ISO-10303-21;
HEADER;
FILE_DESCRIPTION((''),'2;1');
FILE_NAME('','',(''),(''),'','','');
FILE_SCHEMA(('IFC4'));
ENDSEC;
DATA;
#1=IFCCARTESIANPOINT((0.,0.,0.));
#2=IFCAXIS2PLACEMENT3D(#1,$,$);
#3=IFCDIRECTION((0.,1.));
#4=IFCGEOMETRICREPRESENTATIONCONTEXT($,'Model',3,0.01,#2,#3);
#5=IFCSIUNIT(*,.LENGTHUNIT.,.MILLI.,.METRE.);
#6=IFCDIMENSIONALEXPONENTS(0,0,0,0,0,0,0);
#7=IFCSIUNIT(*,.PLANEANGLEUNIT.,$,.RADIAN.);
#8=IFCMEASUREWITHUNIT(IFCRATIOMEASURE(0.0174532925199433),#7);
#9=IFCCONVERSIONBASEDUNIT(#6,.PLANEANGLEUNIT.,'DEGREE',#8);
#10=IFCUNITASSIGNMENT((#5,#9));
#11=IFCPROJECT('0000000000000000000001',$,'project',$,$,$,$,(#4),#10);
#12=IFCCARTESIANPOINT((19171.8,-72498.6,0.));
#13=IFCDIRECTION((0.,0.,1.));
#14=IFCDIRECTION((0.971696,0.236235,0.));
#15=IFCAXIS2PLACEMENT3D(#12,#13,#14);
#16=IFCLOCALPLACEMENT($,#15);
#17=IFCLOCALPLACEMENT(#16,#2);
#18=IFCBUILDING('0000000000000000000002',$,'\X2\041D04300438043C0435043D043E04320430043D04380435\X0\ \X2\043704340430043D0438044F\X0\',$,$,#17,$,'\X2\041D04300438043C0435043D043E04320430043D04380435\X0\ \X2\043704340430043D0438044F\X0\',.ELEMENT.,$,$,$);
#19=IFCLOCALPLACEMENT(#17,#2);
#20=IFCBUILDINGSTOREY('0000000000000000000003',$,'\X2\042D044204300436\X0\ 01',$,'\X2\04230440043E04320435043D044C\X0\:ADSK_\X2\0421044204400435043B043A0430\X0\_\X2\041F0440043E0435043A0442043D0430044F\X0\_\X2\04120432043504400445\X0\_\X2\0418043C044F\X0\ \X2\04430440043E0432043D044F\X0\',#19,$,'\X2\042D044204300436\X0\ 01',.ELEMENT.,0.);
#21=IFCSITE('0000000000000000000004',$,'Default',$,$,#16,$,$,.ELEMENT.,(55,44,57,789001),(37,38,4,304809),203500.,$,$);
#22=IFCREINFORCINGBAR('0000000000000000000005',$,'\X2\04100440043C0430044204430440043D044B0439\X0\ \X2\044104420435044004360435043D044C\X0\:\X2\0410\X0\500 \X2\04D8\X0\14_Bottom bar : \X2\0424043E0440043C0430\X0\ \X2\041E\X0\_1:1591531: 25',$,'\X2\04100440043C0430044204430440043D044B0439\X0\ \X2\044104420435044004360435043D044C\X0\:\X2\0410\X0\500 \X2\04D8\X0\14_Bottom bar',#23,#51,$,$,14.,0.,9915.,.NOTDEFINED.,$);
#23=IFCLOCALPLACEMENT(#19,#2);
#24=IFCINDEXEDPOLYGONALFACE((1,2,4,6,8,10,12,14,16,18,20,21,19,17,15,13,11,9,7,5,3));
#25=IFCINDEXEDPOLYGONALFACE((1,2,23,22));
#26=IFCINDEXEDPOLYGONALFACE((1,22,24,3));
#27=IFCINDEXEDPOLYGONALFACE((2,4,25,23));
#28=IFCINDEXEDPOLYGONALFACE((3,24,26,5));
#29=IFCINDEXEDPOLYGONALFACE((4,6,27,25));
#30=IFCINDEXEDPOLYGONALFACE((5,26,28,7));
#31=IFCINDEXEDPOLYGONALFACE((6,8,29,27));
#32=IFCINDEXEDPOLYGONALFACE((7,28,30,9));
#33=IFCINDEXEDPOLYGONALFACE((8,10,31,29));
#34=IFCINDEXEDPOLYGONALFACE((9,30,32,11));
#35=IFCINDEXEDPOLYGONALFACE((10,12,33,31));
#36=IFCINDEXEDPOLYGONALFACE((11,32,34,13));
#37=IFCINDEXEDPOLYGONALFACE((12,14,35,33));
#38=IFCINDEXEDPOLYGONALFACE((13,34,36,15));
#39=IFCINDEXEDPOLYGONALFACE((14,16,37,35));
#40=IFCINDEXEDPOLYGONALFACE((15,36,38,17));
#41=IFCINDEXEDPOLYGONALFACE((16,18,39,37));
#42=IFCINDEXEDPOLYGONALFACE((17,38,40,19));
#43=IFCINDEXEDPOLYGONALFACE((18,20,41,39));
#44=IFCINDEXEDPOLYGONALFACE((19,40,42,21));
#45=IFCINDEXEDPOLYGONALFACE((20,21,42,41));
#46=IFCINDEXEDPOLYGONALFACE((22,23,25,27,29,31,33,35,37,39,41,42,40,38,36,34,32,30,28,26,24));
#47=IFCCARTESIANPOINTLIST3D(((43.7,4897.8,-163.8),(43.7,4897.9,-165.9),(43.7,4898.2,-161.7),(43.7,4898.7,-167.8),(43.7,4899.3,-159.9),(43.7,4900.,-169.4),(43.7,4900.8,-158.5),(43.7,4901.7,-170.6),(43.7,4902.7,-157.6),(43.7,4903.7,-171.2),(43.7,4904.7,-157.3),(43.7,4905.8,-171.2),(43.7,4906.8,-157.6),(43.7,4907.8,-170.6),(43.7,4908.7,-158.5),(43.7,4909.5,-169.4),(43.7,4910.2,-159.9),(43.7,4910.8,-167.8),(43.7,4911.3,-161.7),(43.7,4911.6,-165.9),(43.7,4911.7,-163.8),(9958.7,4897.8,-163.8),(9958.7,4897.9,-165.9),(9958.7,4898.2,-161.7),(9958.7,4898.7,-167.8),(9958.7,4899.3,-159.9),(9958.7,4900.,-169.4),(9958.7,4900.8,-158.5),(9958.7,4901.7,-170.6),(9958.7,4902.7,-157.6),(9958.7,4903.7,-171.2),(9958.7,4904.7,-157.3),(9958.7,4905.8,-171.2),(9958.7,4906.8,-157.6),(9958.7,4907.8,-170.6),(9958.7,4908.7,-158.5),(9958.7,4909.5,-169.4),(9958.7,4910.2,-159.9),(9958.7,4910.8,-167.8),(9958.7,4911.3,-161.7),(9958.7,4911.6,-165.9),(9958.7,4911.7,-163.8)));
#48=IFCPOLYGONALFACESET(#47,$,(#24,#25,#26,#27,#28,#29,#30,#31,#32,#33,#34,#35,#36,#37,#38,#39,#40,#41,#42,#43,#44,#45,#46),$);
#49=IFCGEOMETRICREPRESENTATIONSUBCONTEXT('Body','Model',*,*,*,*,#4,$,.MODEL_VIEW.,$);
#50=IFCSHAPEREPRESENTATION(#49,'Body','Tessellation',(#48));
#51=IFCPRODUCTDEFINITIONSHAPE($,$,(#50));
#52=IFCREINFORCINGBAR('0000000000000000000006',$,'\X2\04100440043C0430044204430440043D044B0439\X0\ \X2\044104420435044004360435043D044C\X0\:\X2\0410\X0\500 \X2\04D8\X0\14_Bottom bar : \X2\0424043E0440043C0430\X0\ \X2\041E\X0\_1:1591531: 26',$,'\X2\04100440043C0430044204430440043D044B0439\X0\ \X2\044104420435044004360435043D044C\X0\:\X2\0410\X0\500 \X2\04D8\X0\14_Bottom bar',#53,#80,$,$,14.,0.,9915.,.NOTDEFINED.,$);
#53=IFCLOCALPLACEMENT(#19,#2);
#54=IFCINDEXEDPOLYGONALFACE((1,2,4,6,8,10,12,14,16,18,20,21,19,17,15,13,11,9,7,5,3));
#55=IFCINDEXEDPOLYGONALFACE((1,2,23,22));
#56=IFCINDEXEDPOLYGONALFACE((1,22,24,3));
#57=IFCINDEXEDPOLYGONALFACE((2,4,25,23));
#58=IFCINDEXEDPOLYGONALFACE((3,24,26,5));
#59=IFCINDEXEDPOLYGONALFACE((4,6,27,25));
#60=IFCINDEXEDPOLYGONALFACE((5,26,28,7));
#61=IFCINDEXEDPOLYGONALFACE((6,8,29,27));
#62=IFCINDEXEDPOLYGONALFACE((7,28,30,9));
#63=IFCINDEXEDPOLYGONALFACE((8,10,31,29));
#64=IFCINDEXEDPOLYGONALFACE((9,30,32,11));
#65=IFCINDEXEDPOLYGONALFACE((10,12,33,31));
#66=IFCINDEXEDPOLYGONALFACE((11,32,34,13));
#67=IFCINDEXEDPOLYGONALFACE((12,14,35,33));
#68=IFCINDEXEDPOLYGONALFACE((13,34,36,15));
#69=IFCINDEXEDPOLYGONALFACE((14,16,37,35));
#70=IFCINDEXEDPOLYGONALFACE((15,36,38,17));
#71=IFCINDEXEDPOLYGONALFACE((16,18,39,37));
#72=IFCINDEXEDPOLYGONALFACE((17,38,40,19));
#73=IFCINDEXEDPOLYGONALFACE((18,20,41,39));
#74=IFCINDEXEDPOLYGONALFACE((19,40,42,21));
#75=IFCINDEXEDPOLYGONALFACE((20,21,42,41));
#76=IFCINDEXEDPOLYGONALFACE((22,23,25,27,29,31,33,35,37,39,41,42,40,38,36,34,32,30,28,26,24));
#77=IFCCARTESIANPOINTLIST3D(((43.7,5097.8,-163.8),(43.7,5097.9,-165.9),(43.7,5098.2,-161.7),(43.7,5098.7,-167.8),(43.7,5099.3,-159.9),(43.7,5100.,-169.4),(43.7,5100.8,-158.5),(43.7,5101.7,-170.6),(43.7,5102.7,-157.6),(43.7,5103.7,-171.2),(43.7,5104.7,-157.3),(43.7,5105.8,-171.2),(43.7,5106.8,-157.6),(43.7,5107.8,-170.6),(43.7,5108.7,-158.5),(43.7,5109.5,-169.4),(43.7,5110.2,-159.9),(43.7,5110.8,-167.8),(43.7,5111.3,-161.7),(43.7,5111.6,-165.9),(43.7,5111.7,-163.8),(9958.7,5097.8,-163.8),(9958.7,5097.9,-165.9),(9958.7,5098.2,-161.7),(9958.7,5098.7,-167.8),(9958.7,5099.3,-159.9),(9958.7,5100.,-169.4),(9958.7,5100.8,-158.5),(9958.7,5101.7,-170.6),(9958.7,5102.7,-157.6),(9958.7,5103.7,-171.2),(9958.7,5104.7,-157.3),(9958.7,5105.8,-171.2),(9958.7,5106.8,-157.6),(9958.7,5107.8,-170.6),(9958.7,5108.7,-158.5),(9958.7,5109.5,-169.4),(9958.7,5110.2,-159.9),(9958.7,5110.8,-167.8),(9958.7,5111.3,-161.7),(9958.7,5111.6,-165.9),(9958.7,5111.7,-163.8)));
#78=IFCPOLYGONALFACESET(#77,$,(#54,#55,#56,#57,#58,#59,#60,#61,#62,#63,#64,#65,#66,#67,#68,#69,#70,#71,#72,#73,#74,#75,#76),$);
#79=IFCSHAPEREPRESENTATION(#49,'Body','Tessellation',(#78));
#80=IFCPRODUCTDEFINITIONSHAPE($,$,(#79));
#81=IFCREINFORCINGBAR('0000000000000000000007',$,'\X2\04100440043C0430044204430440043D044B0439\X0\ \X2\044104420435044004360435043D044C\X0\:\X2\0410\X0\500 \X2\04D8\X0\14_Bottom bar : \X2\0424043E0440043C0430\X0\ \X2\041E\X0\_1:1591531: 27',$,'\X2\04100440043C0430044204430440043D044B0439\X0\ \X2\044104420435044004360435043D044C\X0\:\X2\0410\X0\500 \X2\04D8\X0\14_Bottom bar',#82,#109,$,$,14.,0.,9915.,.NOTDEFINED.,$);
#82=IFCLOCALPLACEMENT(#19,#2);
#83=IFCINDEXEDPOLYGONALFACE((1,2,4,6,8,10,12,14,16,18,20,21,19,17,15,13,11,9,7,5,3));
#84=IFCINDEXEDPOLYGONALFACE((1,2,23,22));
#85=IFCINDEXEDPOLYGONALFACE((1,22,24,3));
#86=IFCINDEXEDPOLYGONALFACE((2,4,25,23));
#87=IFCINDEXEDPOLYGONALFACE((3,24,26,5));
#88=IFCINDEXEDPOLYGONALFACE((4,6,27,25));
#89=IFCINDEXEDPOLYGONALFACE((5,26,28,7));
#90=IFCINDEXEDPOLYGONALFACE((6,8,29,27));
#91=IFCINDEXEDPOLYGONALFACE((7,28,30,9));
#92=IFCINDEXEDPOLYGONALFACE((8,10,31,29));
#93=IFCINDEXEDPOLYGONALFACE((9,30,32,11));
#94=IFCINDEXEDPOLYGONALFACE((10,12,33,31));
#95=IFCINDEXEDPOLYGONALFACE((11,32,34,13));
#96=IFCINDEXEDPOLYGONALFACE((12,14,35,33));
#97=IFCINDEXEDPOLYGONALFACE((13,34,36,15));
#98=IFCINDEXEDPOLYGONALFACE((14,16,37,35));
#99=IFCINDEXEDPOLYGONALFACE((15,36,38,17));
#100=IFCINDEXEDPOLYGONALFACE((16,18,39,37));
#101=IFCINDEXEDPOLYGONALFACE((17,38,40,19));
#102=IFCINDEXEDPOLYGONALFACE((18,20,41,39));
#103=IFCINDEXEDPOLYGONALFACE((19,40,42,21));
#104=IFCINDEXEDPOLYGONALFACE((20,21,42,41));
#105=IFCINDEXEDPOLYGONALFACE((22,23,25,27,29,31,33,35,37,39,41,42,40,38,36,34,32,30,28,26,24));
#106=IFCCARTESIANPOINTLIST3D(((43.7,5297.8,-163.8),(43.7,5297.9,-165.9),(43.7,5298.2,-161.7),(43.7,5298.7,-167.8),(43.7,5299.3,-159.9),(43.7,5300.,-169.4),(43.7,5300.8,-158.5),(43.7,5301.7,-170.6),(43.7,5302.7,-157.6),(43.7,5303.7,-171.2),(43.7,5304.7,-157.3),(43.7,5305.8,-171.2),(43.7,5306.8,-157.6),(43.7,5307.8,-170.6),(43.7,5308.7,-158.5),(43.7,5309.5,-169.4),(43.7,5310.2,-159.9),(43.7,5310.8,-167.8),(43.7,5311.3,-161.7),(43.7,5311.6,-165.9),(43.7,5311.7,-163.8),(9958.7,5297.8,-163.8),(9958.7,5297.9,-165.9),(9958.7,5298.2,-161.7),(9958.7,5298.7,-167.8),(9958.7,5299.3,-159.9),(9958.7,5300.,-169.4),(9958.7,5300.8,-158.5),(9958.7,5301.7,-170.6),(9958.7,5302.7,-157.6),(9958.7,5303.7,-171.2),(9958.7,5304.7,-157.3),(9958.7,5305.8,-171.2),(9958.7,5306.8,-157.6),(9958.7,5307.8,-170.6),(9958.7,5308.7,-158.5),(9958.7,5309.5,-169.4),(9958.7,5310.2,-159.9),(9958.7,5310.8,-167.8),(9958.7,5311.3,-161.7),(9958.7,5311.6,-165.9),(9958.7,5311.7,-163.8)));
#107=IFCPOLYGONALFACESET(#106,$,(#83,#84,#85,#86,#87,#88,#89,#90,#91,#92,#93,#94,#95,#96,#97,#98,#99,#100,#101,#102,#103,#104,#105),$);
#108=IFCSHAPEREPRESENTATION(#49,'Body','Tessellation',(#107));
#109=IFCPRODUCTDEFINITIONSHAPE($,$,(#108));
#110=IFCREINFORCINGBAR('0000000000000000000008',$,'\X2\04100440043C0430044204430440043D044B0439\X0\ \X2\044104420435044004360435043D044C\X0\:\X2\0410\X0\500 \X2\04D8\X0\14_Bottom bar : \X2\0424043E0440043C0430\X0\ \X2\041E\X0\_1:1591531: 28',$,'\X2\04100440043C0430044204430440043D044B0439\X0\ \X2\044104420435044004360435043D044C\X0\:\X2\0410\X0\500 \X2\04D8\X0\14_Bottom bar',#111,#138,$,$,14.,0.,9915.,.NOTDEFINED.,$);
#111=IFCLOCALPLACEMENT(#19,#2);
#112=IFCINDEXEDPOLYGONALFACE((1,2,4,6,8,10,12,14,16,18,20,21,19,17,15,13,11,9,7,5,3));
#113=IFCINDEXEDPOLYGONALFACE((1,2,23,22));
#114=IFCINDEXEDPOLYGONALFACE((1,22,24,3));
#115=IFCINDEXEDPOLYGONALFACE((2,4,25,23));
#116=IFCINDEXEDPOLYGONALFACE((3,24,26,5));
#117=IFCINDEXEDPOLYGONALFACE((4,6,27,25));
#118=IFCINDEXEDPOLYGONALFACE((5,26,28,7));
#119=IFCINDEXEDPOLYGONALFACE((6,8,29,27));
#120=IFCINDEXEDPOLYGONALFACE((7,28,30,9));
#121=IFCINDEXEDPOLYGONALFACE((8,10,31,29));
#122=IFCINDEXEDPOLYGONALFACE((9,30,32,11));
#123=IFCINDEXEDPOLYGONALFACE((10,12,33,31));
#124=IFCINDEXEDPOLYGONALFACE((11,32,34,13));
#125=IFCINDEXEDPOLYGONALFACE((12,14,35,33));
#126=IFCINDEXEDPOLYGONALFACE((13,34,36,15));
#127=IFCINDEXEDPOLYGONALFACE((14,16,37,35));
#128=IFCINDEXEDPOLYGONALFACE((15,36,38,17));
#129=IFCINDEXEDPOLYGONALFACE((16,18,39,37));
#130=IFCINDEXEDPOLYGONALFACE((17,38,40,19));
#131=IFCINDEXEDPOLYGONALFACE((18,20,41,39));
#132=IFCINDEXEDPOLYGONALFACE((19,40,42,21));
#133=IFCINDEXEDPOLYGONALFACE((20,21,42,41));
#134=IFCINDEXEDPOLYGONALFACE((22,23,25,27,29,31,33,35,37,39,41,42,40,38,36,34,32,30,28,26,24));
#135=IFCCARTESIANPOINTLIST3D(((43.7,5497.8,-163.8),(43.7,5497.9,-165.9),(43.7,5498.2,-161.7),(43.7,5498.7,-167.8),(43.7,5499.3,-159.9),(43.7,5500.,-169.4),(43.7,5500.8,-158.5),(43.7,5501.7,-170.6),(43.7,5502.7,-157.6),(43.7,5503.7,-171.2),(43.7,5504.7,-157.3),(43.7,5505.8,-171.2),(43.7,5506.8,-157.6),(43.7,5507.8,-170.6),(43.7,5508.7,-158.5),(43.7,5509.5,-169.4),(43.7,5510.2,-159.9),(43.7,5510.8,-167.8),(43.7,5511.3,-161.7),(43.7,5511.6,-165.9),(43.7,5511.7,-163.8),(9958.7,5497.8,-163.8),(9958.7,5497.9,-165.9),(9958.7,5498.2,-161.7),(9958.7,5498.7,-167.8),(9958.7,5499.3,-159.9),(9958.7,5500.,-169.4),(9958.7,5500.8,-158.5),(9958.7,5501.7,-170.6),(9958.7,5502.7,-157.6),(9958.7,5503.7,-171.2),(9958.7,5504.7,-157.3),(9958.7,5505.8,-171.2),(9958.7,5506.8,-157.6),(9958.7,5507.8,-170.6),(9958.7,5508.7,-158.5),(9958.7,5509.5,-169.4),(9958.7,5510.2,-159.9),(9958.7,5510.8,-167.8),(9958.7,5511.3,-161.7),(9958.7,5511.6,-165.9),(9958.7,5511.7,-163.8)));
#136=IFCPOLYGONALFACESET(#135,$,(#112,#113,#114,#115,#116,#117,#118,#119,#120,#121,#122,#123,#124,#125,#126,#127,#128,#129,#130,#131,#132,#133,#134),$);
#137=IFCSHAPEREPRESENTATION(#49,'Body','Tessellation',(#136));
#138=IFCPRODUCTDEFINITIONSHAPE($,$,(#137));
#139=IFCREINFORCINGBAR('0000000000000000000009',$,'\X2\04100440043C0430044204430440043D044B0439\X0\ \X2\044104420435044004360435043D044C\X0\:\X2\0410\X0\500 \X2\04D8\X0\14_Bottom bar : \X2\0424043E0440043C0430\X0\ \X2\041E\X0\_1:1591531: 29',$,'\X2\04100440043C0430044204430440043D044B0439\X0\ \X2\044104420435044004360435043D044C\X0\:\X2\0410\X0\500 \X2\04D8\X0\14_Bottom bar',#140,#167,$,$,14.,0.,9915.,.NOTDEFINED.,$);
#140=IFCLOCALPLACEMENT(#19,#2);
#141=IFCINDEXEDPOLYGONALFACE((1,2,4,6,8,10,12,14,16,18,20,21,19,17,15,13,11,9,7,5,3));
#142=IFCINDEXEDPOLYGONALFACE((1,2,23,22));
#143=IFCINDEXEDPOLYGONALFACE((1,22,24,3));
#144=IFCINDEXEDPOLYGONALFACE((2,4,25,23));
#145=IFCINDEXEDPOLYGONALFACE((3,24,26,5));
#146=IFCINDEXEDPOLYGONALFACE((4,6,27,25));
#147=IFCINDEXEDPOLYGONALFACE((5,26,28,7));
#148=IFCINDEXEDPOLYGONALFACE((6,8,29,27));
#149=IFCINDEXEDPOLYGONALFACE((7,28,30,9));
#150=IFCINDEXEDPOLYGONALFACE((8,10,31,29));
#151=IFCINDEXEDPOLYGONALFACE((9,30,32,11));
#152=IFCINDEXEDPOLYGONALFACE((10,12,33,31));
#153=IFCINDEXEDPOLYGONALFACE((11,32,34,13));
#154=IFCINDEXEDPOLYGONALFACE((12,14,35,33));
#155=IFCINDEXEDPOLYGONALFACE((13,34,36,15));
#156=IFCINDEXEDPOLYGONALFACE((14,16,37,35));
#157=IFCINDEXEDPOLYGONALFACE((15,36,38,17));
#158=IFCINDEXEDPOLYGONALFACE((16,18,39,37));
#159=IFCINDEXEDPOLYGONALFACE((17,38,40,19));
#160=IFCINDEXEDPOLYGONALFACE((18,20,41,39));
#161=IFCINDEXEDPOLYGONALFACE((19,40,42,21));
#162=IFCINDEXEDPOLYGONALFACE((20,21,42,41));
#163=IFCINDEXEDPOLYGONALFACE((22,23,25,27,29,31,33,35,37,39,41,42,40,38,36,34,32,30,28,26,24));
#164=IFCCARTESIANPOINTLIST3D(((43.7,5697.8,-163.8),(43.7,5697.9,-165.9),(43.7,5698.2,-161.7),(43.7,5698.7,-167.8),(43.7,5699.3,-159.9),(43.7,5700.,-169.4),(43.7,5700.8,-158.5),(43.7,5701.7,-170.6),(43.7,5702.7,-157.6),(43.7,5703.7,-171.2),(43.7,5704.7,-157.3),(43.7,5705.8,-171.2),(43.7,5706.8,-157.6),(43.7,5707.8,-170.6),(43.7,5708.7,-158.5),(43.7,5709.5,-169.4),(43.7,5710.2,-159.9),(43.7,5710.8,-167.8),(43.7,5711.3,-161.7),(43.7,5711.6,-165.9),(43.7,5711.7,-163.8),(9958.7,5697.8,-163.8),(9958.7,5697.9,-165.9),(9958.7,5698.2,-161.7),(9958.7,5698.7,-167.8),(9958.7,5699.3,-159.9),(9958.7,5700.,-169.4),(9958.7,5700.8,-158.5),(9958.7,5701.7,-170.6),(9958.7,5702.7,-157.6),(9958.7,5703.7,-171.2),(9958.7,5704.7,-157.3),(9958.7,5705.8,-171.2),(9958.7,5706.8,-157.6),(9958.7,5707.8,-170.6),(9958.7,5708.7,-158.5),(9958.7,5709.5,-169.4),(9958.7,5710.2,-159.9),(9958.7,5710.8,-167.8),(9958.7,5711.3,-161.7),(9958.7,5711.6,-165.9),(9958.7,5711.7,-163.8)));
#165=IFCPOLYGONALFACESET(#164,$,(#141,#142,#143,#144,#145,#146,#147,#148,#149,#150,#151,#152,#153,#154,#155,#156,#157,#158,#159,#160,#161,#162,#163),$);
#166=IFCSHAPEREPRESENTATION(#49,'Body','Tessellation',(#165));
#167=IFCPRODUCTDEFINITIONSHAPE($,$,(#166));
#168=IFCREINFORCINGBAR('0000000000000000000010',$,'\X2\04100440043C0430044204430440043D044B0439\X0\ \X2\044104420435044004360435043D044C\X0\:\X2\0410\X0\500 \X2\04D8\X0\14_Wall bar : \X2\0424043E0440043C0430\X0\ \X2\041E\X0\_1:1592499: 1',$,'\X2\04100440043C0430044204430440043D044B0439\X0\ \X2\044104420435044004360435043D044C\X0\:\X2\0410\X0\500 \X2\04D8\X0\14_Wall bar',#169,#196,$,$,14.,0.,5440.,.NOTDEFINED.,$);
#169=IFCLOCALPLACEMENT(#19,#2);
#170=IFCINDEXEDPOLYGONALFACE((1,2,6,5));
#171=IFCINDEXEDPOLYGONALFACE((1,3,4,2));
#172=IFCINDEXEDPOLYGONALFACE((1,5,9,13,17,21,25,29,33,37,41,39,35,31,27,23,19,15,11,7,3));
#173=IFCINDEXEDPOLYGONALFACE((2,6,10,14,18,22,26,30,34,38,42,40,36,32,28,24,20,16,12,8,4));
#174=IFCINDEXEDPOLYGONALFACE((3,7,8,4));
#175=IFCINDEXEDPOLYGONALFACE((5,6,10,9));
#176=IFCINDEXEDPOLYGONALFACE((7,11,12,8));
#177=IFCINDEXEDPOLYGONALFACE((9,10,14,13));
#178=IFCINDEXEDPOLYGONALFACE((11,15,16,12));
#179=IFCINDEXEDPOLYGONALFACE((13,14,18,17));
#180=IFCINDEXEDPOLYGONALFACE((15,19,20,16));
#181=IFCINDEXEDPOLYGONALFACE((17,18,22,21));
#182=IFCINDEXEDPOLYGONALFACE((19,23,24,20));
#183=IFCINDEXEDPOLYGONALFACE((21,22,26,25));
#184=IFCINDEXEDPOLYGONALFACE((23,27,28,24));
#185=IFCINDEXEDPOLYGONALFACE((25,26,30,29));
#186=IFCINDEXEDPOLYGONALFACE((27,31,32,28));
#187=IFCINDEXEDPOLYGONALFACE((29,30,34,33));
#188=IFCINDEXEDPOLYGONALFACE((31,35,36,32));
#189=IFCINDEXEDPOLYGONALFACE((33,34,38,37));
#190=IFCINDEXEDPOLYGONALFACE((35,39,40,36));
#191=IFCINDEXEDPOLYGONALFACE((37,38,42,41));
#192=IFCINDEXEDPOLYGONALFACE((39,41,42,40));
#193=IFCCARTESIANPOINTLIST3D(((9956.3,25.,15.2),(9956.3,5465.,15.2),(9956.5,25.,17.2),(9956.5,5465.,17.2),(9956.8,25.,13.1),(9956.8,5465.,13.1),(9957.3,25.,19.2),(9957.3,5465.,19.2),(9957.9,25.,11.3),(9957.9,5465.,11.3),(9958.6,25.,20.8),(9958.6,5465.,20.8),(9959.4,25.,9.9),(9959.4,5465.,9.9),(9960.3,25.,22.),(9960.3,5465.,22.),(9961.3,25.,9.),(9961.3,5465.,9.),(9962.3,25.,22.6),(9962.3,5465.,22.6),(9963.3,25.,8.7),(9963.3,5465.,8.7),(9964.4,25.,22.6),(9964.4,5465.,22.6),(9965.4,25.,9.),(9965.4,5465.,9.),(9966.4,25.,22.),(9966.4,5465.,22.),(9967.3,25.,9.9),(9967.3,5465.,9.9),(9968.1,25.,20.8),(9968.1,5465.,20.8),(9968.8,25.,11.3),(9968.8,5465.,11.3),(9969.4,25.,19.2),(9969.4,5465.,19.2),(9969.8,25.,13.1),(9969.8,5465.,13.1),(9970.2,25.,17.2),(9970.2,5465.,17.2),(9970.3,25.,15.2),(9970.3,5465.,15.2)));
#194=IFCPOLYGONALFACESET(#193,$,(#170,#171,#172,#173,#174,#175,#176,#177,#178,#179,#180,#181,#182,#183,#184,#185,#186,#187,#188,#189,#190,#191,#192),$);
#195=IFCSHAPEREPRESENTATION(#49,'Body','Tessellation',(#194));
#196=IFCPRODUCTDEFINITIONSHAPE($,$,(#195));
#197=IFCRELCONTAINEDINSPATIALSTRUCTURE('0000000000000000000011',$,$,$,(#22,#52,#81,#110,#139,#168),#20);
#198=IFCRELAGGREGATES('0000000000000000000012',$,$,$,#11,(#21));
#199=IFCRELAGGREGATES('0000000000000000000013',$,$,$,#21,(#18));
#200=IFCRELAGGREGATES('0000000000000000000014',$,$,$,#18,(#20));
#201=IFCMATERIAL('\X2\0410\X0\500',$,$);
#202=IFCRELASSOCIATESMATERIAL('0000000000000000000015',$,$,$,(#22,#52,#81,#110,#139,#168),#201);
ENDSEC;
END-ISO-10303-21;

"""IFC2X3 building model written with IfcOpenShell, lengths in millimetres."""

from ifc_helpers import new_model, entity, si_unit, converted_unit, direction, frame, origin, place, context, subcontext, project, spatial, material, element, save


model = new_model("IFC2X3")

# Units and contexts
model_context = context("Model", 3, precision=0.01, world=origin(), true_north=direction((0.0, 1.0)))
body_context = subcontext(model_context, "Body", "Model", "MODEL_VIEW")
ifc_project = project(units=[si_unit("LENGTHUNIT", "METRE", prefix="MILLI"), converted_unit("PLANEANGLEUNIT", "DEGREE", entity("IfcRatioMeasure", 0.0174532925199433), si_unit("PLANEANGLEUNIT", "RADIAN"), dimensions=[0, 0, 0, 0, 0, 0, 0])], contexts=[model_context])

# Site, building, storey
site_placement = place(None, frame((19171.8, -72498.6, 0.0), z_axis=(0.0, 0.0, 1.0), x_axis=(0.971696, 0.236235, 0.0)))
site = spatial("IfcSite", under=ifc_project, at=site_placement, Name="Default", CompositionType="ELEMENT", RefLatitude=(55, 44, 57, 789001), RefLongitude=(37, 38, 4, 304809), RefElevation=203500.0)
building_placement = place(site_placement, origin())
building = spatial("IfcBuilding", under=site, at=building_placement, Name="Наименование здания", LongName="Наименование здания", CompositionType="ELEMENT")
storey_placement = place(building_placement, origin())
storey = spatial("IfcBuildingStorey", under=building, at=storey_placement, Name="Этаж 01", ObjectType="Уровень:ADSK_Стрелка_Проектная_Вверх_Имя уровня", LongName="Этаж 01", CompositionType="ELEMENT", Elevation=0.0)

# Reinforcing bars
ifc_material = material(Name="А500")
placement = place(storey_placement, origin())
element("IfcReinforcingBar", 1, at=placement, inside=storey, material=ifc_material, Name="Арматурный стержень:А500 Ә14_Bottom bar : Форма О_1:1591531: 25", ObjectType="Арматурный стержень:А500 Ә14_Bottom bar", BarLength=9915.0, BarRole="NOTDEFINED", CrossSectionArea=0.0, NominalDiameter=14.0, context=body_context, shape_type="AdvancedSweptSolid", body=[
    entity("IfcSweptDiskSolid", entity("IfcCompositeCurve", [entity("IfcCompositeCurveSegment", "CONTINUOUS", True, entity("IfcPolyline", [entity("IfcCartesianPoint", [43.7, 4904.7, -164.3]), entity("IfcCartesianPoint", [9958.7, 4904.7, -164.3])]))], False), 7.0, None, 0.0, 1.0),
])
element("IfcReinforcingBar", 2, at=placement, inside=storey, material=ifc_material, Name="Арматурный стержень:А500 Ә14_Bottom bar : Форма О_1:1591531: 26", ObjectType="Арматурный стержень:А500 Ә14_Bottom bar", BarLength=9915.0, BarRole="NOTDEFINED", CrossSectionArea=0.0, NominalDiameter=14.0, context=body_context, shape_type="AdvancedSweptSolid", body=[
    entity("IfcSweptDiskSolid", entity("IfcCompositeCurve", [entity("IfcCompositeCurveSegment", "CONTINUOUS", True, entity("IfcPolyline", [entity("IfcCartesianPoint", [43.7, 5104.7, -164.3]), entity("IfcCartesianPoint", [9958.7, 5104.7, -164.3])]))], False), 7.0, None, 0.0, 1.0),
])
element("IfcReinforcingBar", 3, at=placement, inside=storey, material=ifc_material, Name="Арматурный стержень:А500 Ә14_Bottom bar : Форма О_1:1591531: 27", ObjectType="Арматурный стержень:А500 Ә14_Bottom bar", BarLength=9915.0, BarRole="NOTDEFINED", CrossSectionArea=0.0, NominalDiameter=14.0, context=body_context, shape_type="AdvancedSweptSolid", body=[
    entity("IfcSweptDiskSolid", entity("IfcCompositeCurve", [entity("IfcCompositeCurveSegment", "CONTINUOUS", True, entity("IfcPolyline", [entity("IfcCartesianPoint", [43.7, 5304.7, -164.3]), entity("IfcCartesianPoint", [9958.7, 5304.7, -164.3])]))], False), 7.0, None, 0.0, 1.0),
])
element("IfcReinforcingBar", 4, at=placement, inside=storey, material=ifc_material, Name="Арматурный стержень:А500 Ә14_Bottom bar : Форма О_1:1591531: 28", ObjectType="Арматурный стержень:А500 Ә14_Bottom bar", BarLength=9915.0, BarRole="NOTDEFINED", CrossSectionArea=0.0, NominalDiameter=14.0, context=body_context, shape_type="AdvancedSweptSolid", body=[
    entity("IfcSweptDiskSolid", entity("IfcCompositeCurve", [entity("IfcCompositeCurveSegment", "CONTINUOUS", True, entity("IfcPolyline", [entity("IfcCartesianPoint", [43.7, 5504.7, -164.3]), entity("IfcCartesianPoint", [9958.7, 5504.7, -164.3])]))], False), 7.0, None, 0.0, 1.0),
])
element("IfcReinforcingBar", 5, at=placement, inside=storey, material=ifc_material, Name="Арматурный стержень:А500 Ә14_Bottom bar : Форма О_1:1591531: 29", ObjectType="Арматурный стержень:А500 Ә14_Bottom bar", BarLength=9915.0, BarRole="NOTDEFINED", CrossSectionArea=0.0, NominalDiameter=14.0, context=body_context, shape_type="AdvancedSweptSolid", body=[
    entity("IfcSweptDiskSolid", entity("IfcCompositeCurve", [entity("IfcCompositeCurveSegment", "CONTINUOUS", True, entity("IfcPolyline", [entity("IfcCartesianPoint", [43.7, 5704.7, -164.3]), entity("IfcCartesianPoint", [9958.7, 5704.7, -164.3])]))], False), 7.0, None, 0.0, 1.0),
])
element("IfcReinforcingBar", 6, at=placement, inside=storey, material=ifc_material, Name="Арматурный стержень:А500 Ә14_Wall bar : Форма О_1:1592499: 1", ObjectType="Арматурный стержень:А500 Ә14_Wall bar", BarLength=5440.0, BarRole="NOTDEFINED", CrossSectionArea=0.0, NominalDiameter=14.0, context=body_context, shape_type="AdvancedSweptSolid", body=[
    entity("IfcSweptDiskSolid", entity("IfcCompositeCurve", [entity("IfcCompositeCurveSegment", "CONTINUOUS", True, entity("IfcPolyline", [entity("IfcCartesianPoint", [9963.3, 5465.0, 15.7]), entity("IfcCartesianPoint", [9963.3, 25.0, 15.7])]))], False), 7.0, None, 0.0, 1.0),
])

save(model, "model.ifc")
